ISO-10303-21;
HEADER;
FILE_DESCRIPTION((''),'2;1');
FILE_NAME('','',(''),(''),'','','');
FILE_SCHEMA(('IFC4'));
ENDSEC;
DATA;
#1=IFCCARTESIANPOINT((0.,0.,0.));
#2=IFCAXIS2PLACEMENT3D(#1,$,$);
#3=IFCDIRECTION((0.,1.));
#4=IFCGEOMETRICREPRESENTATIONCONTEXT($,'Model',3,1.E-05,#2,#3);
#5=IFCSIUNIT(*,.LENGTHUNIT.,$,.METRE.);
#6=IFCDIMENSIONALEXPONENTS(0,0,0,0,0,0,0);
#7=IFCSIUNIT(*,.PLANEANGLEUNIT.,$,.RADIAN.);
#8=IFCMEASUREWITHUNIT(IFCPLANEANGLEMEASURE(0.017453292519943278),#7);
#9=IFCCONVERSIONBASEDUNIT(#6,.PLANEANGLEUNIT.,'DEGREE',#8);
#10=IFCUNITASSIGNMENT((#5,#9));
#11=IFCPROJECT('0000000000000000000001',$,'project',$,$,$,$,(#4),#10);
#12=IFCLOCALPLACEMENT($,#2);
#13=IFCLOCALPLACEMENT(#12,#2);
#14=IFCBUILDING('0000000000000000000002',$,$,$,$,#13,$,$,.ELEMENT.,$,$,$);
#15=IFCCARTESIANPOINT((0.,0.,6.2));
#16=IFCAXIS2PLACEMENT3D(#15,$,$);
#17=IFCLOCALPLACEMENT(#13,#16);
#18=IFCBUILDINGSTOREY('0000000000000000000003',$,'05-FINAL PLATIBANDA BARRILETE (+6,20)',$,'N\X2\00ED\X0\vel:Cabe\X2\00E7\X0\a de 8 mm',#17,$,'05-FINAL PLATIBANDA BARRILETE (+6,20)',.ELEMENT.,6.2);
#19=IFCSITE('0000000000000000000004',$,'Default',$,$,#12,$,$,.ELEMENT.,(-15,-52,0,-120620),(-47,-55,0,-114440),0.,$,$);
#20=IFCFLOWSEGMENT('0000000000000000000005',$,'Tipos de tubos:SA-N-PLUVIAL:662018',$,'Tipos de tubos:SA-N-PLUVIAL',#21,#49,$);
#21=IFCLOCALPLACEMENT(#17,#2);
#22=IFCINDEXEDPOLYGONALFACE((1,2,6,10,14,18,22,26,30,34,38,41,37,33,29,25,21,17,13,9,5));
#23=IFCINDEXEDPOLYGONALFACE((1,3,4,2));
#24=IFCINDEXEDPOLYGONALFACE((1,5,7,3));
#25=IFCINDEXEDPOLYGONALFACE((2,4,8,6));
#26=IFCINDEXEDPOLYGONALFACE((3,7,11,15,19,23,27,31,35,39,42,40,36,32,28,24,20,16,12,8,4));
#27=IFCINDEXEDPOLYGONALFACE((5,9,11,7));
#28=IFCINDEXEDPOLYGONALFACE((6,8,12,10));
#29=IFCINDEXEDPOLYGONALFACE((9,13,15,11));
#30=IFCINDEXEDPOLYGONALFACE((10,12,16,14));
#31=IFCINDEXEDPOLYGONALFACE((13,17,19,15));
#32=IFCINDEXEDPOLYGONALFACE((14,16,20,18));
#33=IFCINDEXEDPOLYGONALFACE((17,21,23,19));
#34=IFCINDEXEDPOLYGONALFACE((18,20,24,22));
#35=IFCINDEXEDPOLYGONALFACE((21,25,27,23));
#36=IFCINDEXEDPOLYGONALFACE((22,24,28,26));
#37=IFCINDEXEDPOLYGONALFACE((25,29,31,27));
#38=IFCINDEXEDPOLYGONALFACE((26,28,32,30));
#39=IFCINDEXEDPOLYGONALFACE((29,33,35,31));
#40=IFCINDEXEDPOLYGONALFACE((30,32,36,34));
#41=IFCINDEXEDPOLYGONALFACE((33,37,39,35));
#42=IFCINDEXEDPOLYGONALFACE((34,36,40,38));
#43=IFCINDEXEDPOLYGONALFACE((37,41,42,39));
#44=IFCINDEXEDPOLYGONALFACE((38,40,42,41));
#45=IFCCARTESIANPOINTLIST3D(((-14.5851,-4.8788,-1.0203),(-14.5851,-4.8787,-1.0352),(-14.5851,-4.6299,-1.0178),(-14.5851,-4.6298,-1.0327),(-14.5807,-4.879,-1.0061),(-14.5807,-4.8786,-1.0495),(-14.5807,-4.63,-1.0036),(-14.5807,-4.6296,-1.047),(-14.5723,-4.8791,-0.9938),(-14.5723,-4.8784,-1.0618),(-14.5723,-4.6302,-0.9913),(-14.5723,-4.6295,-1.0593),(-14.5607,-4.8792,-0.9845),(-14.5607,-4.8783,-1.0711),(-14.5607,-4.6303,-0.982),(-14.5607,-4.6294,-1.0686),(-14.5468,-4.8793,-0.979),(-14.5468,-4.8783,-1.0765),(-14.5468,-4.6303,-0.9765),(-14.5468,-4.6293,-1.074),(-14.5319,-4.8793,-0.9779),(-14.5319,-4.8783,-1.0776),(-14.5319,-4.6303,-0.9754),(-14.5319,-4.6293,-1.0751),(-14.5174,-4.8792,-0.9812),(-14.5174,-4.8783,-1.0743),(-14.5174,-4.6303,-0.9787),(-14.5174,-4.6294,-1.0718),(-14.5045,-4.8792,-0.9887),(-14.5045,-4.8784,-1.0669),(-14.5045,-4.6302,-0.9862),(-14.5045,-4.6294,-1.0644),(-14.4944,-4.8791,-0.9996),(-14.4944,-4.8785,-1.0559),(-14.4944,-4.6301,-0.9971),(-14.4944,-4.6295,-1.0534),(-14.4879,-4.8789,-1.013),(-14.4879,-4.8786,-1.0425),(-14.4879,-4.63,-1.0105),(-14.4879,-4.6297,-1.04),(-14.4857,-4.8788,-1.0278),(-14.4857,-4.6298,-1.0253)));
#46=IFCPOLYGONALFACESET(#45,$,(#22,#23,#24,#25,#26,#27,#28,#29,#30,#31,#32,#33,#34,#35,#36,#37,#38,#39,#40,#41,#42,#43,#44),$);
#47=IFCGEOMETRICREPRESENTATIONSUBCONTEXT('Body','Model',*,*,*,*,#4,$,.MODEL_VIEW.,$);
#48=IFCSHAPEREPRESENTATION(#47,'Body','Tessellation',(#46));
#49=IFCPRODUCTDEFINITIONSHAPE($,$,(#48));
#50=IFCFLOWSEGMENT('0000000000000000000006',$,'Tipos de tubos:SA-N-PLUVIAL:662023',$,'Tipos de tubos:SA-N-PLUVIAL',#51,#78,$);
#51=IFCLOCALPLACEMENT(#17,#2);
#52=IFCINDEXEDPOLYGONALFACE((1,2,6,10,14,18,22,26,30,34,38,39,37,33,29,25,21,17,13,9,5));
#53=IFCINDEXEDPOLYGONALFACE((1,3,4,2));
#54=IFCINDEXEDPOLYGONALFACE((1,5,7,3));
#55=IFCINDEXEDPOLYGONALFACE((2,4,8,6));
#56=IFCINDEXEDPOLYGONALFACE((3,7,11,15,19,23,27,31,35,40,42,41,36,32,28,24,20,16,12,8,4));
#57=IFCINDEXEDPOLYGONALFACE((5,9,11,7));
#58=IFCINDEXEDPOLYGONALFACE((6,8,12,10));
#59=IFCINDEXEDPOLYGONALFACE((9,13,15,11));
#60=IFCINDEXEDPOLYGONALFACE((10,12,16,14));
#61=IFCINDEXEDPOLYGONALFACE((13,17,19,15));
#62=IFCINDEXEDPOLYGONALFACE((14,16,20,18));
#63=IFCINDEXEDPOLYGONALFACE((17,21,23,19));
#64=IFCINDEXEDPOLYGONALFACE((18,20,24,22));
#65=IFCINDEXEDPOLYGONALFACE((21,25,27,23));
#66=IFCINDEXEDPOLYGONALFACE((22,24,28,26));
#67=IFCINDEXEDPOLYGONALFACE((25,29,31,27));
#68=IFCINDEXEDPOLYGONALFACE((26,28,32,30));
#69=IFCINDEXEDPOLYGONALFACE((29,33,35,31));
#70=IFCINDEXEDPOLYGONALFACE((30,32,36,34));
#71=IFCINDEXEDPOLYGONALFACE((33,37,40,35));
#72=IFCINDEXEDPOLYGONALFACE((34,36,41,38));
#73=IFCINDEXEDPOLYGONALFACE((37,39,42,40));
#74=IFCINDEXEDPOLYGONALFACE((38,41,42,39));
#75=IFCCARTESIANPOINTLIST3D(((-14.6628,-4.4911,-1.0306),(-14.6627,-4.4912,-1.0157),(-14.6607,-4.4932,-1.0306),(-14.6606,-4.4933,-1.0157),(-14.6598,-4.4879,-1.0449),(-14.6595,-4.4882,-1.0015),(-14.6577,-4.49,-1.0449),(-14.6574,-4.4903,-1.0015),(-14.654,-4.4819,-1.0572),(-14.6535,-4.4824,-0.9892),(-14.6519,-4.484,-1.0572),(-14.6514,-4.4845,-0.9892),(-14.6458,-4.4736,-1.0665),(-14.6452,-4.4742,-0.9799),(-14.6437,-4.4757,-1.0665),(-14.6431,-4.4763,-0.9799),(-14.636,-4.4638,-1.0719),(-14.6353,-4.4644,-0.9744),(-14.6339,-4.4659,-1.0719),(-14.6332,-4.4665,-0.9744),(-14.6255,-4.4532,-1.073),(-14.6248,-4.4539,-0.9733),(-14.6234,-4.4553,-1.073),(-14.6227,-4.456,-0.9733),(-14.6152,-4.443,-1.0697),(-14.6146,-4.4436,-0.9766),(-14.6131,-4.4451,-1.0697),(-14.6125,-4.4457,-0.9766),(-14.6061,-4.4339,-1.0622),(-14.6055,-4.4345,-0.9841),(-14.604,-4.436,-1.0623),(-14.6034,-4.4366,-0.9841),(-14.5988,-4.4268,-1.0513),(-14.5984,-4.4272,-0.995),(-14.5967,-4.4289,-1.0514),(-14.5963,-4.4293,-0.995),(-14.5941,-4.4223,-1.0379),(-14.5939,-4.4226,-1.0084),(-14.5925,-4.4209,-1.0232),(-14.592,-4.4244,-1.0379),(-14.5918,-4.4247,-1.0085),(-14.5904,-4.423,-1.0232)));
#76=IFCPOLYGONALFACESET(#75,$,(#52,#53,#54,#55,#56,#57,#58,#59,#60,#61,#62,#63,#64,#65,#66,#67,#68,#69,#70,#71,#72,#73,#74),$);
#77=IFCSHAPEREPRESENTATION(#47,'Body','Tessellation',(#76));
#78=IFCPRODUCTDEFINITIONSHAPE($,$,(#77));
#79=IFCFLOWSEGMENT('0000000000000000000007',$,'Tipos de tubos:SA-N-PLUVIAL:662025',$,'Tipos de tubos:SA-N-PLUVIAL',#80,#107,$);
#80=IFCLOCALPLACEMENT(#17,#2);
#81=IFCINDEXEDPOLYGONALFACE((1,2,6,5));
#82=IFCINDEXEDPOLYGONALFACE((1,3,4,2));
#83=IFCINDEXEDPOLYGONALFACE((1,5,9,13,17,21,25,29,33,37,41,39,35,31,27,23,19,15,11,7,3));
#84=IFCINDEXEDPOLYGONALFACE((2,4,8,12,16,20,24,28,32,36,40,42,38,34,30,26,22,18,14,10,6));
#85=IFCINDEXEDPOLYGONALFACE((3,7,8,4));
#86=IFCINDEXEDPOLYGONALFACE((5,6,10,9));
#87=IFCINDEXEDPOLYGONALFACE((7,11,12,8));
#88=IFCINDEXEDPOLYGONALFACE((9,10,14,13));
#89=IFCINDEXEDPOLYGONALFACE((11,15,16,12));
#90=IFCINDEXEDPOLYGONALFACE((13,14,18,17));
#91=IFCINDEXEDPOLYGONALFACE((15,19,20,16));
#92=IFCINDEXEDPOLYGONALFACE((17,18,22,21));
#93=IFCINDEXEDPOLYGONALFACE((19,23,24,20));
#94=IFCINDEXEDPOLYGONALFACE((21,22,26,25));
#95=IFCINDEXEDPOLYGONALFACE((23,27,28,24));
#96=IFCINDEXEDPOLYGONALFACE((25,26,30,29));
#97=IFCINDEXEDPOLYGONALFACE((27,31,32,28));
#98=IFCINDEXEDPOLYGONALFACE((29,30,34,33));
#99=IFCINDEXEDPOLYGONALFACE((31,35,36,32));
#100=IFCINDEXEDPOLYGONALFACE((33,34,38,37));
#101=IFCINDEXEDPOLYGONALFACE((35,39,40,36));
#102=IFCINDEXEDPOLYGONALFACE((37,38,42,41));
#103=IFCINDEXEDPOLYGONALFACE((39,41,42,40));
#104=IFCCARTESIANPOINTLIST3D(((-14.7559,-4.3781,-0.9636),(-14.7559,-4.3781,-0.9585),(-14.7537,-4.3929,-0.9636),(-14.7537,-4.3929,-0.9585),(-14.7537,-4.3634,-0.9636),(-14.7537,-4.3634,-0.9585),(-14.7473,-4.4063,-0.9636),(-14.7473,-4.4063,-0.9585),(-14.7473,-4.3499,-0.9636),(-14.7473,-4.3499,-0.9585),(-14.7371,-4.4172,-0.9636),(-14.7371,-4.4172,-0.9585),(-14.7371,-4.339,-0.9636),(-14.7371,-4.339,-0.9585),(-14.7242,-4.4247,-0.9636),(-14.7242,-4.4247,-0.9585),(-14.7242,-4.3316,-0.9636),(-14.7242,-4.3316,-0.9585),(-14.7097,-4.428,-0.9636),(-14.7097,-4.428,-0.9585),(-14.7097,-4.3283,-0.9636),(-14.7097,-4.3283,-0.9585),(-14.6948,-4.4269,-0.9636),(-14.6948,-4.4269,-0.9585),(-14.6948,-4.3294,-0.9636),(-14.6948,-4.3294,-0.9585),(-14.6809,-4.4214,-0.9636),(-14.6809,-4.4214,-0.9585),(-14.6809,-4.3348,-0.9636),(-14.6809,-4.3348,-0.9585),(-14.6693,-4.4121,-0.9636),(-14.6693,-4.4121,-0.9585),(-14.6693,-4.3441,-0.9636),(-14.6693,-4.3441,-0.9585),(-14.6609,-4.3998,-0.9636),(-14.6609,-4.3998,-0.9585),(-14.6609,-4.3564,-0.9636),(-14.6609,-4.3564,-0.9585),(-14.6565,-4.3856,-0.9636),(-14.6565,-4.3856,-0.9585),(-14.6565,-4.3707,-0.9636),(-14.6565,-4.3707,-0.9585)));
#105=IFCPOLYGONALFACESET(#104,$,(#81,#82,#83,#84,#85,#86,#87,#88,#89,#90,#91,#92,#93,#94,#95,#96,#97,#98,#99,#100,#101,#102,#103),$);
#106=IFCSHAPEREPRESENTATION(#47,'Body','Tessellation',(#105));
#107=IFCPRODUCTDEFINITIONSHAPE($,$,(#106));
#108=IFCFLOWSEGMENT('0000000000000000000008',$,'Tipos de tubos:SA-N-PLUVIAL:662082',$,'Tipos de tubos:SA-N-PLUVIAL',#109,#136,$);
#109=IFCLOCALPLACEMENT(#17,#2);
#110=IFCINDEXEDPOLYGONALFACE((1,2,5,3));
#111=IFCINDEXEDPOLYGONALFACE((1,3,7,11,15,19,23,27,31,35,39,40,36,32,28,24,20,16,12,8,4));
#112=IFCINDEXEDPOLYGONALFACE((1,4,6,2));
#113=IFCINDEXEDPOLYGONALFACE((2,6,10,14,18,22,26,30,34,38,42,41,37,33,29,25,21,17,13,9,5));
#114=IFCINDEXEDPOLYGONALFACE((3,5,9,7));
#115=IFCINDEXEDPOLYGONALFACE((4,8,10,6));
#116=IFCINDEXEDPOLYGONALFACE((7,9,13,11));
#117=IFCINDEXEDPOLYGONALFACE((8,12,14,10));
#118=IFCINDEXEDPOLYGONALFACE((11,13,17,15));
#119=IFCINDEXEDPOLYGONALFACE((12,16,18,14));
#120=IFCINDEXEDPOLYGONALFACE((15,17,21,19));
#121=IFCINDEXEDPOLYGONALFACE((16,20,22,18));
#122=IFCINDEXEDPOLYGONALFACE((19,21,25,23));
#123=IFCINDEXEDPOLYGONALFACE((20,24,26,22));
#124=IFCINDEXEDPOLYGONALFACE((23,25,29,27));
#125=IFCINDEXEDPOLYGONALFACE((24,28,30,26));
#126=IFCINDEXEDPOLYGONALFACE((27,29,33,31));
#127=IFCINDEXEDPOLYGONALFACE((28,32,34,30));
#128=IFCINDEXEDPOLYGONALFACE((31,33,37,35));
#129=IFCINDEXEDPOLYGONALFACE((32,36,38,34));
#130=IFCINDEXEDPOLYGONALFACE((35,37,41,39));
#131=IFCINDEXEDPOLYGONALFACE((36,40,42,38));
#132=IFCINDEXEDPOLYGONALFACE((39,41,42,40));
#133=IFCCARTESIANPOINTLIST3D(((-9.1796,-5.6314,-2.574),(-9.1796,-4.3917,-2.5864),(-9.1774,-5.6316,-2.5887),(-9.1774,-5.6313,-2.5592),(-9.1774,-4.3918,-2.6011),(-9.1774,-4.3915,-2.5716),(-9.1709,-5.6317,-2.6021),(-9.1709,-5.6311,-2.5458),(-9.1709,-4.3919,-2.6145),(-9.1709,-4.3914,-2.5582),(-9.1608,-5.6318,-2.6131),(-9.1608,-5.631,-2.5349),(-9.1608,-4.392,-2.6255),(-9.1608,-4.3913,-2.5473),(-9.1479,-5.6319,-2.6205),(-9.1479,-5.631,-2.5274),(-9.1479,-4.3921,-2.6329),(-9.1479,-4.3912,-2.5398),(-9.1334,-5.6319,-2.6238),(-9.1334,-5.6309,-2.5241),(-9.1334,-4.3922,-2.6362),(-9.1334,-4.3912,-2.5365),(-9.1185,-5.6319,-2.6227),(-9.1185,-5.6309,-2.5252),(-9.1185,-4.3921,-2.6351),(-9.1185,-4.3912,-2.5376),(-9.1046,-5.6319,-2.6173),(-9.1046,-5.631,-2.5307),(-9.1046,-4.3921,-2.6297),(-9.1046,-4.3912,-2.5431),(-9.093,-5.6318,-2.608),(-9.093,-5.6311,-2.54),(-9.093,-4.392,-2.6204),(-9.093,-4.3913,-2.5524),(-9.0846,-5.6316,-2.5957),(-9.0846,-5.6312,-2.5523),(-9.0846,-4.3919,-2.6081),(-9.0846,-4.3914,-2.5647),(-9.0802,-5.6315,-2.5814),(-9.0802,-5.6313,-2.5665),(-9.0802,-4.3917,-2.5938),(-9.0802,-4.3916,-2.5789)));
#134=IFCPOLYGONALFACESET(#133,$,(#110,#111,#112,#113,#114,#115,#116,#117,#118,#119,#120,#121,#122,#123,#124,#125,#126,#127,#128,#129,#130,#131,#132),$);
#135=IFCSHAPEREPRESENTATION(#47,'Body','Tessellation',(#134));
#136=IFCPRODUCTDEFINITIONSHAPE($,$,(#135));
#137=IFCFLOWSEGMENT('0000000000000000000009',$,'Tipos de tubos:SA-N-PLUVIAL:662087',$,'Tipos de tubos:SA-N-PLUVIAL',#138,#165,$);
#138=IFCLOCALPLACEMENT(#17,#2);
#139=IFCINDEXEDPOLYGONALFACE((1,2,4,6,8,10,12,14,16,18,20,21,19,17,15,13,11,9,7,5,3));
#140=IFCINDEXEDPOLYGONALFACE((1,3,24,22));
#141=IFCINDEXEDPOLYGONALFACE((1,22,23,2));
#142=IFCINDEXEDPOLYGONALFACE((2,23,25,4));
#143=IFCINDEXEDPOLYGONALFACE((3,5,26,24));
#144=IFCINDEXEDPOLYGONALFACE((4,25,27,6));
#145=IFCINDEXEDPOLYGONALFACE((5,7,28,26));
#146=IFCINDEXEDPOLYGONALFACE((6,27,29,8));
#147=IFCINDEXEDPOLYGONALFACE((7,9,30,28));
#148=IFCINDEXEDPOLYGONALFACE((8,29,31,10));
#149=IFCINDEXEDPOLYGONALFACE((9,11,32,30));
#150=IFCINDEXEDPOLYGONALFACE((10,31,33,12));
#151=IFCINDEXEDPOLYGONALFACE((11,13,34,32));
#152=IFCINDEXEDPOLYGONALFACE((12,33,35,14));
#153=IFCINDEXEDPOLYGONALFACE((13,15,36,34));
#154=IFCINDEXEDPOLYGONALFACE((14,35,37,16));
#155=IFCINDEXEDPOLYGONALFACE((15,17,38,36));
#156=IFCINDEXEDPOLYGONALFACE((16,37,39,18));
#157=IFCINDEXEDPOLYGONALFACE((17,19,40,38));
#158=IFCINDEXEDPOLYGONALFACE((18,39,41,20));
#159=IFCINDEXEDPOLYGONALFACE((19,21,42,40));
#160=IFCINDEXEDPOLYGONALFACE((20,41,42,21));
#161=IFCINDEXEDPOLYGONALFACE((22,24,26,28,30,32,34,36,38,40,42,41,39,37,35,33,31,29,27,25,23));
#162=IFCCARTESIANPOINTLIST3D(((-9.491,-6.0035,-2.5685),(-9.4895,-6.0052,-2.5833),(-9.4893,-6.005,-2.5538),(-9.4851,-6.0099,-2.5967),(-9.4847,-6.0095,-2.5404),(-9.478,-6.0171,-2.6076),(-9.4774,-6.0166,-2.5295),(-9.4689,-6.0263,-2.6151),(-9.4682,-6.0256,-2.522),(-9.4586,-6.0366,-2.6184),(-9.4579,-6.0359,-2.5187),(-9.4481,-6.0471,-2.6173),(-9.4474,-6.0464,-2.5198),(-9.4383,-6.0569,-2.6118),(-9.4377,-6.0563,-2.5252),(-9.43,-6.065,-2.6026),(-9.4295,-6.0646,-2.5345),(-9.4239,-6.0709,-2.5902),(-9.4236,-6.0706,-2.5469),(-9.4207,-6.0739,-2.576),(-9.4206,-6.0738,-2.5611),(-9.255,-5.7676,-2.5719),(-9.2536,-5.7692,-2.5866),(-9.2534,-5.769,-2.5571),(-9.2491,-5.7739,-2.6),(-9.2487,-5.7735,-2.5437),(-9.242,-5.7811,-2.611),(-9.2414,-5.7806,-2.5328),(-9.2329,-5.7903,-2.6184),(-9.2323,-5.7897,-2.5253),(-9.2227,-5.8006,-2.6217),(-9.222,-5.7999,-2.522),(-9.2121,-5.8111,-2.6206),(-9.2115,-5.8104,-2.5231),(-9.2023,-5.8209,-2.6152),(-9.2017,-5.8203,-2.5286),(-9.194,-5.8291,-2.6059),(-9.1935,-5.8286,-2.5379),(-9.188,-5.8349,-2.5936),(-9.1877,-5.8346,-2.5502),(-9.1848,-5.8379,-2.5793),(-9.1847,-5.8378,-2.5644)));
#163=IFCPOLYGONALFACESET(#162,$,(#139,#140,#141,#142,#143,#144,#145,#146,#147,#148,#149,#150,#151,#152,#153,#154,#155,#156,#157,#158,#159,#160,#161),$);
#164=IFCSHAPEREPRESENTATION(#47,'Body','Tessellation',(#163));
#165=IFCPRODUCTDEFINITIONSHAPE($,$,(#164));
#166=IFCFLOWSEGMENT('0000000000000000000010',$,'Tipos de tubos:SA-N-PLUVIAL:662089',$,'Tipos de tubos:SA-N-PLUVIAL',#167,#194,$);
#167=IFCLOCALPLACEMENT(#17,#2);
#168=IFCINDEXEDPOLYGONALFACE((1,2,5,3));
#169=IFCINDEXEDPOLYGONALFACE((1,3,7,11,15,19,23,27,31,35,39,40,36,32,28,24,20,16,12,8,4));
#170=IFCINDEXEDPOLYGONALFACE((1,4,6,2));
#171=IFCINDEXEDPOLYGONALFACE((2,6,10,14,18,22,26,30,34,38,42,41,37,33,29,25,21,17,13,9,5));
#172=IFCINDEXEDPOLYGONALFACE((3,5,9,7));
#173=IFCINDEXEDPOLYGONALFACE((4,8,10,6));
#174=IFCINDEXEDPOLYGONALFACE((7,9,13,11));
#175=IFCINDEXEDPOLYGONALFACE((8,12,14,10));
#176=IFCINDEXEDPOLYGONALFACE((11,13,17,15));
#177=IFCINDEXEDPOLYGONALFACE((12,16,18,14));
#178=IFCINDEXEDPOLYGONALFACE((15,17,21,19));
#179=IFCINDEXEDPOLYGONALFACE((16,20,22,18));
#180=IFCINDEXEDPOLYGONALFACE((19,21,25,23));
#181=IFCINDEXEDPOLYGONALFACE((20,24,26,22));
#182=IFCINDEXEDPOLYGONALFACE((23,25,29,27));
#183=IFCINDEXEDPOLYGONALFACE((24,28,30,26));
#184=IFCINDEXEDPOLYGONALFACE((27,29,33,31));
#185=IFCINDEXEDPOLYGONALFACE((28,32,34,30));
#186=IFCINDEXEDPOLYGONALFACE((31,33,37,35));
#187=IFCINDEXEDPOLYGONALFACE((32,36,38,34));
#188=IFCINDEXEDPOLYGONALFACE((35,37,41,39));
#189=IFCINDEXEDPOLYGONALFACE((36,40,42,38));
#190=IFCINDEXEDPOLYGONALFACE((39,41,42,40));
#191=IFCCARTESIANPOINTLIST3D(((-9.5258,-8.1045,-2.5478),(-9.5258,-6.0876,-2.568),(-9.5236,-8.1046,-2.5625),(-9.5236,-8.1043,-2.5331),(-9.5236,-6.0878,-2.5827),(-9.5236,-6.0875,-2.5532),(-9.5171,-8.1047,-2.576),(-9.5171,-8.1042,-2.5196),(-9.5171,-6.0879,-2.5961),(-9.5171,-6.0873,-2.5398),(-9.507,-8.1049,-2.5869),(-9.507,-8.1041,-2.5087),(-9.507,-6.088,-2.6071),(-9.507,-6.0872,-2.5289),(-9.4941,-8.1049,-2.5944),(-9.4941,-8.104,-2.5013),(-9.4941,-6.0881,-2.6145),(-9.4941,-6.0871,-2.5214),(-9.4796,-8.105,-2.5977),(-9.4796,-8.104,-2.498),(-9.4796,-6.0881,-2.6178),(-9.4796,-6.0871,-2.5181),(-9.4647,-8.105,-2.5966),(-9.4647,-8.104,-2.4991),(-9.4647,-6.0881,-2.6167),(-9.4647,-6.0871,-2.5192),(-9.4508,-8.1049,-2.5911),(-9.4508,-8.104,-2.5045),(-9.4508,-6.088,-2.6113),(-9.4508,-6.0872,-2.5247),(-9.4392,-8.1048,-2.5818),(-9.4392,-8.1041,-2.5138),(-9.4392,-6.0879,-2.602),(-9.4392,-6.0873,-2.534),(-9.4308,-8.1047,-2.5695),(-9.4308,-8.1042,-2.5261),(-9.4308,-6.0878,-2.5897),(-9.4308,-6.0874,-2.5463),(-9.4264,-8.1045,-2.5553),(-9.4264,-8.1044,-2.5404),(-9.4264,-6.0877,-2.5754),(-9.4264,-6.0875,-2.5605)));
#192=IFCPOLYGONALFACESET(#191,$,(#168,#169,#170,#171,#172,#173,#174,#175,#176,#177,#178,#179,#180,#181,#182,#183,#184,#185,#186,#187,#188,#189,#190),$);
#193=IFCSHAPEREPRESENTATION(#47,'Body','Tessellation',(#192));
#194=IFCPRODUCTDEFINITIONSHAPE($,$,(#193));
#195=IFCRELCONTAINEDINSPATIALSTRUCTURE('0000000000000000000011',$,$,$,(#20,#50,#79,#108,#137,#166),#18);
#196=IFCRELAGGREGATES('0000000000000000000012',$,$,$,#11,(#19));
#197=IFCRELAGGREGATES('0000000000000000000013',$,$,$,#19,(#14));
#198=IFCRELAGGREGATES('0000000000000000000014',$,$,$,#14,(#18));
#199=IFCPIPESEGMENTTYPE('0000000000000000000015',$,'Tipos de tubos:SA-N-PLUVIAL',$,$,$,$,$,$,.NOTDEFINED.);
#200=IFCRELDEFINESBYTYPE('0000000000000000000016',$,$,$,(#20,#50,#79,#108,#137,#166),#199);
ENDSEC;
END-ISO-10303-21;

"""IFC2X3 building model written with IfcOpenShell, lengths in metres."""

from ifc_helpers import new_model, entity, si_unit, converted_unit, direction, frame, frame_2d, origin, origin_2d_with_axis, place, context, subcontext, project, spatial, circle, extrude, type_object, element, save


model = new_model("IFC2X3")

# Units and contexts
model_context = context("Model", 3, precision=1e-05, world=origin(), true_north=direction((0.0, 1.0)))
body_context = subcontext(model_context, "Body", "Model", "MODEL_VIEW")
ifc_project = project(units=[si_unit("LENGTHUNIT", "METRE"), converted_unit("PLANEANGLEUNIT", "DEGREE", entity("IfcPlaneAngleMeasure", 0.017453292519943278), si_unit("PLANEANGLEUNIT", "RADIAN"), dimensions=[0, 0, 0, 0, 0, 0, 0])], contexts=[model_context])

# Site, building, storey
site_placement = place(None, origin())
site = spatial("IfcSite", under=ifc_project, at=site_placement, Name="Default", CompositionType="ELEMENT", RefLatitude=(-15, -52, 0, -120620), RefLongitude=(-47, -55, 0, -114440), RefElevation=0.0)
building_placement = place(site_placement, origin())
building = spatial("IfcBuilding", under=site, at=building_placement, CompositionType="ELEMENT")
storey_placement = place(building_placement, frame((0.0, 0.0, 6.2)))
storey = spatial("IfcBuildingStorey", under=building, at=storey_placement, Name="05-FINAL PLATIBANDA BARRILETE (+6,20)", ObjectType="Nível:Cabeça de 8 mm", LongName="05-FINAL PLATIBANDA BARRILETE (+6,20)", CompositionType="ELEMENT", Elevation=6.2)

# Flow segments
pipe_segment_type_1 = type_object("IfcPipeSegmentType", Name="Tipos de tubos:SA-N-PLUVIAL", PredefinedType="NOTDEFINED")
flow_segment_1_placement = place(storey_placement, origin())
element("IfcFlowSegment", 1, at=flow_segment_1_placement, inside=storey, type_object=pipe_segment_type_1, Name="Tipos de tubos:SA-N-PLUVIAL:662018", ObjectType="Tipos de tubos:SA-N-PLUVIAL", context=body_context, shape_type="SweptSolid", body=[
    extrude(circle(Radius=0.05, at=frame_2d((0.0, 0.0), x_axis=(1.0, 0.0))), frame((-14.5357, -4.8788, -1.0278), z_axis=(-0.000001, 0.99995, 0.01), x_axis=(1.0, 0.000001, 0.0)), (0.0, 0.0, 1.0), 0.249),
])
flow_segment_2_placement = place(storey_placement, origin())
element("IfcFlowSegment", 2, at=flow_segment_2_placement, inside=storey, type_object=pipe_segment_type_1, Name="Tipos de tubos:SA-N-PLUVIAL:662023", ObjectType="Tipos de tubos:SA-N-PLUVIAL", context=body_context, shape_type="SweptSolid", body=[
    extrude(circle(Radius=0.05, at=frame_2d((0.0, 0.0), x_axis=(1.0, 0.0))), frame((-14.6257, -4.4583, -1.0232), z_axis=(-0.707072, 0.707071, 0.01), x_axis=(0.707106, 0.707107, 0.0)), (0.0, 0.0, 1.0), 0.003),
])
flow_segment_3_placement = place(storey_placement, origin())
element("IfcFlowSegment", 3, at=flow_segment_3_placement, inside=storey, type_object=pipe_segment_type_1, Name="Tipos de tubos:SA-N-PLUVIAL:662025", ObjectType="Tipos de tubos:SA-N-PLUVIAL", context=body_context, shape_type="SweptSolid", body=[
    extrude(circle(Radius=0.05, at=origin_2d_with_axis()), frame((-14.7059, -4.3781, -0.9636), z_axis=(0.0, 0.0, 1.0), x_axis=(-1.0, 0.0, 0.0)), (0.0, 0.0, 1.0), 0.0051),
])
flow_segment_4_placement = place(storey_placement, origin())
element("IfcFlowSegment", 4, at=flow_segment_4_placement, inside=storey, type_object=pipe_segment_type_1, Name="Tipos de tubos:SA-N-PLUVIAL:662082", ObjectType="Tipos de tubos:SA-N-PLUVIAL", context=body_context, shape_type="SweptSolid", body=[
    extrude(circle(Radius=0.05, at=frame_2d((0.0, 0.0), x_axis=(1.0, 0.0))), frame((-9.1296, -5.6314, -2.574), z_axis=(-0.000001, 0.99995, -0.01), x_axis=(-1.0, -0.000001, 0.0)), (0.0, 0.0, 1.0), 1.2398),
])
flow_segment_5_placement = place(storey_placement, origin())
element("IfcFlowSegment", 5, at=flow_segment_5_placement, inside=storey, type_object=pipe_segment_type_1, Name="Tipos de tubos:SA-N-PLUVIAL:662087", ObjectType="Tipos de tubos:SA-N-PLUVIAL", context=body_context, shape_type="SweptSolid", body=[
    extrude(circle(Radius=0.05, at=frame_2d((0.0, 0.0), x_axis=(1.0, 0.0))), frame((-9.2197, -5.8029, -2.5719), z_axis=(-0.707071, -0.707072, 0.01), x_axis=(-0.707107, 0.707106, 0.0)), (0.0, 0.0, 1.0), 0.3337),
])
flow_segment_6_placement = place(storey_placement, origin())
element("IfcFlowSegment", 6, at=flow_segment_6_placement, inside=storey, type_object=pipe_segment_type_1, Name="Tipos de tubos:SA-N-PLUVIAL:662089", ObjectType="Tipos de tubos:SA-N-PLUVIAL", context=body_context, shape_type="SweptSolid", body=[
    extrude(circle(Radius=0.05, at=origin_2d_with_axis()), frame((-9.4758, -8.1045, -2.5478), z_axis=(-0.000001, 0.99995, -0.01), x_axis=(-1.0, -0.000001, 0.0)), (0.0, 0.0, 1.0), 2.017),
])

save(model, "model.ifc")
